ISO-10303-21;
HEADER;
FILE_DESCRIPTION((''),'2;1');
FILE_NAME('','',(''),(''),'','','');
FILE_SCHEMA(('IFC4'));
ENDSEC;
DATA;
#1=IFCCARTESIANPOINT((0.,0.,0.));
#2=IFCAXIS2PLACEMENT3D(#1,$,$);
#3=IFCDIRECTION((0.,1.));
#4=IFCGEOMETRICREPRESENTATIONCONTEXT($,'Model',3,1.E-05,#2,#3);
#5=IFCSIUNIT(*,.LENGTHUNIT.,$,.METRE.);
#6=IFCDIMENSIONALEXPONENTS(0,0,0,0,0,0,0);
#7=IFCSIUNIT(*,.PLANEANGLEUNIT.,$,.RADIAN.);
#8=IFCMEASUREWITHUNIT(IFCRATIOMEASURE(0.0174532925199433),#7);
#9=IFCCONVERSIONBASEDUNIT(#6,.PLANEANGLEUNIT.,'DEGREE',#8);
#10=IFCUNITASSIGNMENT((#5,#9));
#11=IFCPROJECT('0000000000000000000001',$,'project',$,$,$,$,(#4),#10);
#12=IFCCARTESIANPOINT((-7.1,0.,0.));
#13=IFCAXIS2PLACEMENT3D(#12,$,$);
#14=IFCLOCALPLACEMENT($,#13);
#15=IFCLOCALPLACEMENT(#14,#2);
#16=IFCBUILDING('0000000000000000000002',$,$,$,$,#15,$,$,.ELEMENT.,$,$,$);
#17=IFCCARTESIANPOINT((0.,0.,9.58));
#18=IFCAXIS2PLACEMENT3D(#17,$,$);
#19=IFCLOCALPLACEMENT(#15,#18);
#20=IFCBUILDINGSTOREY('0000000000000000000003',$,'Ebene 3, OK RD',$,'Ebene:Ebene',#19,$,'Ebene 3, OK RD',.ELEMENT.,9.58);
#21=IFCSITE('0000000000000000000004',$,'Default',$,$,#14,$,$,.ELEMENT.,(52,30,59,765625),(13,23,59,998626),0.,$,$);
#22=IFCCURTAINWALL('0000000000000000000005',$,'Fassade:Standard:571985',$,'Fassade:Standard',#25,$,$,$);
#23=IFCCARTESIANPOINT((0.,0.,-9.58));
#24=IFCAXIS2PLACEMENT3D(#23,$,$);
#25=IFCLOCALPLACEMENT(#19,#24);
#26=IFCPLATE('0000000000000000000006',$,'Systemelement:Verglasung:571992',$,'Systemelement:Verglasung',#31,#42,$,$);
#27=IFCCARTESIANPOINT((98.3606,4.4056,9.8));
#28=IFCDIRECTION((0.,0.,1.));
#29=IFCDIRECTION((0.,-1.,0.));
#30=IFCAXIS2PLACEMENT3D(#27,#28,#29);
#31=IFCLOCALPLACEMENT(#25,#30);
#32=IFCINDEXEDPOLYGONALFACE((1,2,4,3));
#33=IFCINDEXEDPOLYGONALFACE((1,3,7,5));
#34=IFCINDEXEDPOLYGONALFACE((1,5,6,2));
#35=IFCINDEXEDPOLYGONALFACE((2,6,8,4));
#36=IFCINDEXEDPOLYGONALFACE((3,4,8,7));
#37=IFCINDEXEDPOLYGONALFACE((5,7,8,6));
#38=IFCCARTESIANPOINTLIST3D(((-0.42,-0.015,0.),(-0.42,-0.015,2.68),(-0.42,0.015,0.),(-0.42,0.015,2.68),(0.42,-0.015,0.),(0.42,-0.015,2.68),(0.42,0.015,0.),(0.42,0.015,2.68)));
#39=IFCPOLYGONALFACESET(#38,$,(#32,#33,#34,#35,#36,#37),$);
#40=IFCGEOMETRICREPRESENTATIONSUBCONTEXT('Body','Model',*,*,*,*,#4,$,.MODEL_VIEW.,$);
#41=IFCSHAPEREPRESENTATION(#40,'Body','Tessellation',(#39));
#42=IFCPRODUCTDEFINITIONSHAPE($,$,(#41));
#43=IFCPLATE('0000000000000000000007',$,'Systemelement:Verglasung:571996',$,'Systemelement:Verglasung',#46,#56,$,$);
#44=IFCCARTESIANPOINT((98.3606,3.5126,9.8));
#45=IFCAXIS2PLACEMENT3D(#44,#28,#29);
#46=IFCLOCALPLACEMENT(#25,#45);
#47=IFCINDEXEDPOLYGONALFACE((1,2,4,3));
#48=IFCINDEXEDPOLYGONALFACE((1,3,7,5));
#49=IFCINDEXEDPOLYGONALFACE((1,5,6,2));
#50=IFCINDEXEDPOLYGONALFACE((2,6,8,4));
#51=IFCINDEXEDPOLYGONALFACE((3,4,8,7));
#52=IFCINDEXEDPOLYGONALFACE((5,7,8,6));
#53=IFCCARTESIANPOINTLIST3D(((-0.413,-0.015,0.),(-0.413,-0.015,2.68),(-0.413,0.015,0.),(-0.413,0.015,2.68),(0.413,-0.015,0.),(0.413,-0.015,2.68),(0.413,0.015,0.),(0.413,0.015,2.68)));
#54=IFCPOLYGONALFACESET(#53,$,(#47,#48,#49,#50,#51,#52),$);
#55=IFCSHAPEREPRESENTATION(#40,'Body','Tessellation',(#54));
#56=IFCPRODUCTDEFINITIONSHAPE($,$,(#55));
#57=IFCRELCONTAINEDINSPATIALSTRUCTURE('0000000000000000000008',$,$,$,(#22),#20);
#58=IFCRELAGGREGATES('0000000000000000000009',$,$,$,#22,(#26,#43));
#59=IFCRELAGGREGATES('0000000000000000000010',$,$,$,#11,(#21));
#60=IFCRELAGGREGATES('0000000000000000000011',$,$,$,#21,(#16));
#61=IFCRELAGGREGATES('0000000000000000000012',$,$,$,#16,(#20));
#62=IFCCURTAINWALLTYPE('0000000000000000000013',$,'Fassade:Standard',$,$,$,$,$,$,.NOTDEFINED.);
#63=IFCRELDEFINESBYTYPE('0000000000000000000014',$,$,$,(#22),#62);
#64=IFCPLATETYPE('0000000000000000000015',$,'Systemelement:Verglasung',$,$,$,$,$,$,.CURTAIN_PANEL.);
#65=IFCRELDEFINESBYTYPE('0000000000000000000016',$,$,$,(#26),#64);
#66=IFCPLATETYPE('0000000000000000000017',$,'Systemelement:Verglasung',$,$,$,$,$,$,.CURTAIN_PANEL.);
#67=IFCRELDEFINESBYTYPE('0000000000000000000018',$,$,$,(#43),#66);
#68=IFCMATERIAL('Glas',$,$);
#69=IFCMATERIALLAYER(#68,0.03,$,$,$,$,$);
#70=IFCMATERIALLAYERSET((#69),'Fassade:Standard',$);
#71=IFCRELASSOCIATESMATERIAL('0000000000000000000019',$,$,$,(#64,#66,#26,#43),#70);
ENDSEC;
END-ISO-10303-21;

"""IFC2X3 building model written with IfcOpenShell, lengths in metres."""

from ifc_helpers import new_model, entity, si_unit, converted_unit, direction, frame, origin, origin_2d_with_axis, place, context, subcontext, project, spatial, rectangle, extrude, source, transform, mapped, material, layer, layer_set, layer_usage, type_object, type_shapes, element, aggregate, save


model = new_model("IFC2X3")

# Units and contexts
model_context = context("Model", 3, precision=1e-05, world=origin(), true_north=direction((0.0, 1.0)))
body_context = subcontext(model_context, "Body", "Model", "MODEL_VIEW")
ifc_project = project(units=[si_unit("LENGTHUNIT", "METRE"), converted_unit("PLANEANGLEUNIT", "DEGREE", entity("IfcRatioMeasure", 0.0174532925199433), si_unit("PLANEANGLEUNIT", "RADIAN"), dimensions=[0, 0, 0, 0, 0, 0, 0])], contexts=[model_context])

# Site, building, storey
site_placement = place(None, frame((-7.1, 0.0, 0.0)))
site = spatial("IfcSite", under=ifc_project, at=site_placement, Name="Default", CompositionType="ELEMENT", RefLatitude=(52, 30, 59, 765625), RefLongitude=(13, 23, 59, 998626), RefElevation=0.0)
building_placement = place(site_placement, origin())
building = spatial("IfcBuilding", under=site, at=building_placement, CompositionType="ELEMENT")
storey_placement = place(building_placement, frame((0.0, 0.0, 9.58)))
storey = spatial("IfcBuildingStorey", under=building, at=storey_placement, Name="Ebene 3, OK RD", ObjectType="Ebene:Ebene", LongName="Ebene 3, OK RD", CompositionType="ELEMENT", Elevation=9.58)

# Curtain wall, plates
curtain_wall_type = type_object("IfcCurtainWallType", Name="Fassade:Standard", PredefinedType="NOTDEFINED")
curtain_wall_placement = place(storey_placement, frame((0.0, 0.0, -9.58)))
curtain_wall = element("IfcCurtainWall", 1, at=curtain_wall_placement, inside=storey, type_object=curtain_wall_type, Name="Fassade:Standard:571985", ObjectType="Fassade:Standard")
ifc_material_1 = material(Name="Glas")
ifc_layer_1 = layer(ifc_material_1, 0.03)
ifc_layer_set_1 = layer_set([ifc_layer_1], Name="Fassade:Standard")
ifc_layer_usage_1 = layer_usage(ifc_layer_set_1, "AXIS3", "POSITIVE", 0.0)
plate_type_1 = type_object("IfcPlateType", Name="Systemelement:Verglasung", PredefinedType="CURTAIN_PANEL", material=ifc_layer_set_1)
shared_shape_1 = source(origin(), body_context, "Body", "SweptSolid", [
    extrude(rectangle(XDim=0.03, YDim=0.84, at=origin_2d_with_axis()), frame((0.0, 0.0, 0.0), z_axis=(0.0, 0.0, 1.0), x_axis=(0.0, 1.0, 0.0)), (0.0, 0.0, 1.0), 2.68),
])
type_shapes(plate_type_1, [shared_shape_1])
plate_1_placement = place(curtain_wall_placement, frame((98.3606, 4.4056, 9.8), z_axis=(0.0, 0.0, 1.0), x_axis=(0.0, -1.0, 0.0)))
plate_1 = element("IfcPlate", 2, at=plate_1_placement, type_object=plate_type_1, material=ifc_layer_usage_1, Name="Systemelement:Verglasung:571992", ObjectType="Systemelement:Verglasung", context=body_context, shape_type="MappedRepresentation", body=[
    mapped(shared_shape_1, transform((0.0, 0.0, 0.0), scale=1.0)),
])
ifc_layer_usage_2 = layer_usage(ifc_layer_set_1, "AXIS3", "POSITIVE", 0.0)
plate_type_2 = type_object("IfcPlateType", Name="Systemelement:Verglasung", PredefinedType="CURTAIN_PANEL", material=ifc_layer_set_1)
shared_shape_2 = source(origin(), body_context, "Body", "SweptSolid", [
    extrude(rectangle(XDim=0.03, YDim=0.826, at=origin_2d_with_axis()), frame((0.0, 0.0, 0.0), z_axis=(0.0, 0.0, 1.0), x_axis=(0.0, 1.0, 0.0)), (0.0, 0.0, 1.0), 2.68),
])
type_shapes(plate_type_2, [shared_shape_2])
plate_2_placement = place(curtain_wall_placement, frame((98.3606, 3.5126, 9.8), z_axis=(0.0, 0.0, 1.0), x_axis=(0.0, -1.0, 0.0)))
plate_2 = element("IfcPlate", 3, at=plate_2_placement, type_object=plate_type_2, material=ifc_layer_usage_2, Name="Systemelement:Verglasung:571996", ObjectType="Systemelement:Verglasung", context=body_context, shape_type="MappedRepresentation", body=[
    mapped(shared_shape_2, transform((0.0, 0.0, 0.0), scale=1.0)),
])
aggregate(curtain_wall, [plate_1, plate_2])

save(model, "model.ifc")
